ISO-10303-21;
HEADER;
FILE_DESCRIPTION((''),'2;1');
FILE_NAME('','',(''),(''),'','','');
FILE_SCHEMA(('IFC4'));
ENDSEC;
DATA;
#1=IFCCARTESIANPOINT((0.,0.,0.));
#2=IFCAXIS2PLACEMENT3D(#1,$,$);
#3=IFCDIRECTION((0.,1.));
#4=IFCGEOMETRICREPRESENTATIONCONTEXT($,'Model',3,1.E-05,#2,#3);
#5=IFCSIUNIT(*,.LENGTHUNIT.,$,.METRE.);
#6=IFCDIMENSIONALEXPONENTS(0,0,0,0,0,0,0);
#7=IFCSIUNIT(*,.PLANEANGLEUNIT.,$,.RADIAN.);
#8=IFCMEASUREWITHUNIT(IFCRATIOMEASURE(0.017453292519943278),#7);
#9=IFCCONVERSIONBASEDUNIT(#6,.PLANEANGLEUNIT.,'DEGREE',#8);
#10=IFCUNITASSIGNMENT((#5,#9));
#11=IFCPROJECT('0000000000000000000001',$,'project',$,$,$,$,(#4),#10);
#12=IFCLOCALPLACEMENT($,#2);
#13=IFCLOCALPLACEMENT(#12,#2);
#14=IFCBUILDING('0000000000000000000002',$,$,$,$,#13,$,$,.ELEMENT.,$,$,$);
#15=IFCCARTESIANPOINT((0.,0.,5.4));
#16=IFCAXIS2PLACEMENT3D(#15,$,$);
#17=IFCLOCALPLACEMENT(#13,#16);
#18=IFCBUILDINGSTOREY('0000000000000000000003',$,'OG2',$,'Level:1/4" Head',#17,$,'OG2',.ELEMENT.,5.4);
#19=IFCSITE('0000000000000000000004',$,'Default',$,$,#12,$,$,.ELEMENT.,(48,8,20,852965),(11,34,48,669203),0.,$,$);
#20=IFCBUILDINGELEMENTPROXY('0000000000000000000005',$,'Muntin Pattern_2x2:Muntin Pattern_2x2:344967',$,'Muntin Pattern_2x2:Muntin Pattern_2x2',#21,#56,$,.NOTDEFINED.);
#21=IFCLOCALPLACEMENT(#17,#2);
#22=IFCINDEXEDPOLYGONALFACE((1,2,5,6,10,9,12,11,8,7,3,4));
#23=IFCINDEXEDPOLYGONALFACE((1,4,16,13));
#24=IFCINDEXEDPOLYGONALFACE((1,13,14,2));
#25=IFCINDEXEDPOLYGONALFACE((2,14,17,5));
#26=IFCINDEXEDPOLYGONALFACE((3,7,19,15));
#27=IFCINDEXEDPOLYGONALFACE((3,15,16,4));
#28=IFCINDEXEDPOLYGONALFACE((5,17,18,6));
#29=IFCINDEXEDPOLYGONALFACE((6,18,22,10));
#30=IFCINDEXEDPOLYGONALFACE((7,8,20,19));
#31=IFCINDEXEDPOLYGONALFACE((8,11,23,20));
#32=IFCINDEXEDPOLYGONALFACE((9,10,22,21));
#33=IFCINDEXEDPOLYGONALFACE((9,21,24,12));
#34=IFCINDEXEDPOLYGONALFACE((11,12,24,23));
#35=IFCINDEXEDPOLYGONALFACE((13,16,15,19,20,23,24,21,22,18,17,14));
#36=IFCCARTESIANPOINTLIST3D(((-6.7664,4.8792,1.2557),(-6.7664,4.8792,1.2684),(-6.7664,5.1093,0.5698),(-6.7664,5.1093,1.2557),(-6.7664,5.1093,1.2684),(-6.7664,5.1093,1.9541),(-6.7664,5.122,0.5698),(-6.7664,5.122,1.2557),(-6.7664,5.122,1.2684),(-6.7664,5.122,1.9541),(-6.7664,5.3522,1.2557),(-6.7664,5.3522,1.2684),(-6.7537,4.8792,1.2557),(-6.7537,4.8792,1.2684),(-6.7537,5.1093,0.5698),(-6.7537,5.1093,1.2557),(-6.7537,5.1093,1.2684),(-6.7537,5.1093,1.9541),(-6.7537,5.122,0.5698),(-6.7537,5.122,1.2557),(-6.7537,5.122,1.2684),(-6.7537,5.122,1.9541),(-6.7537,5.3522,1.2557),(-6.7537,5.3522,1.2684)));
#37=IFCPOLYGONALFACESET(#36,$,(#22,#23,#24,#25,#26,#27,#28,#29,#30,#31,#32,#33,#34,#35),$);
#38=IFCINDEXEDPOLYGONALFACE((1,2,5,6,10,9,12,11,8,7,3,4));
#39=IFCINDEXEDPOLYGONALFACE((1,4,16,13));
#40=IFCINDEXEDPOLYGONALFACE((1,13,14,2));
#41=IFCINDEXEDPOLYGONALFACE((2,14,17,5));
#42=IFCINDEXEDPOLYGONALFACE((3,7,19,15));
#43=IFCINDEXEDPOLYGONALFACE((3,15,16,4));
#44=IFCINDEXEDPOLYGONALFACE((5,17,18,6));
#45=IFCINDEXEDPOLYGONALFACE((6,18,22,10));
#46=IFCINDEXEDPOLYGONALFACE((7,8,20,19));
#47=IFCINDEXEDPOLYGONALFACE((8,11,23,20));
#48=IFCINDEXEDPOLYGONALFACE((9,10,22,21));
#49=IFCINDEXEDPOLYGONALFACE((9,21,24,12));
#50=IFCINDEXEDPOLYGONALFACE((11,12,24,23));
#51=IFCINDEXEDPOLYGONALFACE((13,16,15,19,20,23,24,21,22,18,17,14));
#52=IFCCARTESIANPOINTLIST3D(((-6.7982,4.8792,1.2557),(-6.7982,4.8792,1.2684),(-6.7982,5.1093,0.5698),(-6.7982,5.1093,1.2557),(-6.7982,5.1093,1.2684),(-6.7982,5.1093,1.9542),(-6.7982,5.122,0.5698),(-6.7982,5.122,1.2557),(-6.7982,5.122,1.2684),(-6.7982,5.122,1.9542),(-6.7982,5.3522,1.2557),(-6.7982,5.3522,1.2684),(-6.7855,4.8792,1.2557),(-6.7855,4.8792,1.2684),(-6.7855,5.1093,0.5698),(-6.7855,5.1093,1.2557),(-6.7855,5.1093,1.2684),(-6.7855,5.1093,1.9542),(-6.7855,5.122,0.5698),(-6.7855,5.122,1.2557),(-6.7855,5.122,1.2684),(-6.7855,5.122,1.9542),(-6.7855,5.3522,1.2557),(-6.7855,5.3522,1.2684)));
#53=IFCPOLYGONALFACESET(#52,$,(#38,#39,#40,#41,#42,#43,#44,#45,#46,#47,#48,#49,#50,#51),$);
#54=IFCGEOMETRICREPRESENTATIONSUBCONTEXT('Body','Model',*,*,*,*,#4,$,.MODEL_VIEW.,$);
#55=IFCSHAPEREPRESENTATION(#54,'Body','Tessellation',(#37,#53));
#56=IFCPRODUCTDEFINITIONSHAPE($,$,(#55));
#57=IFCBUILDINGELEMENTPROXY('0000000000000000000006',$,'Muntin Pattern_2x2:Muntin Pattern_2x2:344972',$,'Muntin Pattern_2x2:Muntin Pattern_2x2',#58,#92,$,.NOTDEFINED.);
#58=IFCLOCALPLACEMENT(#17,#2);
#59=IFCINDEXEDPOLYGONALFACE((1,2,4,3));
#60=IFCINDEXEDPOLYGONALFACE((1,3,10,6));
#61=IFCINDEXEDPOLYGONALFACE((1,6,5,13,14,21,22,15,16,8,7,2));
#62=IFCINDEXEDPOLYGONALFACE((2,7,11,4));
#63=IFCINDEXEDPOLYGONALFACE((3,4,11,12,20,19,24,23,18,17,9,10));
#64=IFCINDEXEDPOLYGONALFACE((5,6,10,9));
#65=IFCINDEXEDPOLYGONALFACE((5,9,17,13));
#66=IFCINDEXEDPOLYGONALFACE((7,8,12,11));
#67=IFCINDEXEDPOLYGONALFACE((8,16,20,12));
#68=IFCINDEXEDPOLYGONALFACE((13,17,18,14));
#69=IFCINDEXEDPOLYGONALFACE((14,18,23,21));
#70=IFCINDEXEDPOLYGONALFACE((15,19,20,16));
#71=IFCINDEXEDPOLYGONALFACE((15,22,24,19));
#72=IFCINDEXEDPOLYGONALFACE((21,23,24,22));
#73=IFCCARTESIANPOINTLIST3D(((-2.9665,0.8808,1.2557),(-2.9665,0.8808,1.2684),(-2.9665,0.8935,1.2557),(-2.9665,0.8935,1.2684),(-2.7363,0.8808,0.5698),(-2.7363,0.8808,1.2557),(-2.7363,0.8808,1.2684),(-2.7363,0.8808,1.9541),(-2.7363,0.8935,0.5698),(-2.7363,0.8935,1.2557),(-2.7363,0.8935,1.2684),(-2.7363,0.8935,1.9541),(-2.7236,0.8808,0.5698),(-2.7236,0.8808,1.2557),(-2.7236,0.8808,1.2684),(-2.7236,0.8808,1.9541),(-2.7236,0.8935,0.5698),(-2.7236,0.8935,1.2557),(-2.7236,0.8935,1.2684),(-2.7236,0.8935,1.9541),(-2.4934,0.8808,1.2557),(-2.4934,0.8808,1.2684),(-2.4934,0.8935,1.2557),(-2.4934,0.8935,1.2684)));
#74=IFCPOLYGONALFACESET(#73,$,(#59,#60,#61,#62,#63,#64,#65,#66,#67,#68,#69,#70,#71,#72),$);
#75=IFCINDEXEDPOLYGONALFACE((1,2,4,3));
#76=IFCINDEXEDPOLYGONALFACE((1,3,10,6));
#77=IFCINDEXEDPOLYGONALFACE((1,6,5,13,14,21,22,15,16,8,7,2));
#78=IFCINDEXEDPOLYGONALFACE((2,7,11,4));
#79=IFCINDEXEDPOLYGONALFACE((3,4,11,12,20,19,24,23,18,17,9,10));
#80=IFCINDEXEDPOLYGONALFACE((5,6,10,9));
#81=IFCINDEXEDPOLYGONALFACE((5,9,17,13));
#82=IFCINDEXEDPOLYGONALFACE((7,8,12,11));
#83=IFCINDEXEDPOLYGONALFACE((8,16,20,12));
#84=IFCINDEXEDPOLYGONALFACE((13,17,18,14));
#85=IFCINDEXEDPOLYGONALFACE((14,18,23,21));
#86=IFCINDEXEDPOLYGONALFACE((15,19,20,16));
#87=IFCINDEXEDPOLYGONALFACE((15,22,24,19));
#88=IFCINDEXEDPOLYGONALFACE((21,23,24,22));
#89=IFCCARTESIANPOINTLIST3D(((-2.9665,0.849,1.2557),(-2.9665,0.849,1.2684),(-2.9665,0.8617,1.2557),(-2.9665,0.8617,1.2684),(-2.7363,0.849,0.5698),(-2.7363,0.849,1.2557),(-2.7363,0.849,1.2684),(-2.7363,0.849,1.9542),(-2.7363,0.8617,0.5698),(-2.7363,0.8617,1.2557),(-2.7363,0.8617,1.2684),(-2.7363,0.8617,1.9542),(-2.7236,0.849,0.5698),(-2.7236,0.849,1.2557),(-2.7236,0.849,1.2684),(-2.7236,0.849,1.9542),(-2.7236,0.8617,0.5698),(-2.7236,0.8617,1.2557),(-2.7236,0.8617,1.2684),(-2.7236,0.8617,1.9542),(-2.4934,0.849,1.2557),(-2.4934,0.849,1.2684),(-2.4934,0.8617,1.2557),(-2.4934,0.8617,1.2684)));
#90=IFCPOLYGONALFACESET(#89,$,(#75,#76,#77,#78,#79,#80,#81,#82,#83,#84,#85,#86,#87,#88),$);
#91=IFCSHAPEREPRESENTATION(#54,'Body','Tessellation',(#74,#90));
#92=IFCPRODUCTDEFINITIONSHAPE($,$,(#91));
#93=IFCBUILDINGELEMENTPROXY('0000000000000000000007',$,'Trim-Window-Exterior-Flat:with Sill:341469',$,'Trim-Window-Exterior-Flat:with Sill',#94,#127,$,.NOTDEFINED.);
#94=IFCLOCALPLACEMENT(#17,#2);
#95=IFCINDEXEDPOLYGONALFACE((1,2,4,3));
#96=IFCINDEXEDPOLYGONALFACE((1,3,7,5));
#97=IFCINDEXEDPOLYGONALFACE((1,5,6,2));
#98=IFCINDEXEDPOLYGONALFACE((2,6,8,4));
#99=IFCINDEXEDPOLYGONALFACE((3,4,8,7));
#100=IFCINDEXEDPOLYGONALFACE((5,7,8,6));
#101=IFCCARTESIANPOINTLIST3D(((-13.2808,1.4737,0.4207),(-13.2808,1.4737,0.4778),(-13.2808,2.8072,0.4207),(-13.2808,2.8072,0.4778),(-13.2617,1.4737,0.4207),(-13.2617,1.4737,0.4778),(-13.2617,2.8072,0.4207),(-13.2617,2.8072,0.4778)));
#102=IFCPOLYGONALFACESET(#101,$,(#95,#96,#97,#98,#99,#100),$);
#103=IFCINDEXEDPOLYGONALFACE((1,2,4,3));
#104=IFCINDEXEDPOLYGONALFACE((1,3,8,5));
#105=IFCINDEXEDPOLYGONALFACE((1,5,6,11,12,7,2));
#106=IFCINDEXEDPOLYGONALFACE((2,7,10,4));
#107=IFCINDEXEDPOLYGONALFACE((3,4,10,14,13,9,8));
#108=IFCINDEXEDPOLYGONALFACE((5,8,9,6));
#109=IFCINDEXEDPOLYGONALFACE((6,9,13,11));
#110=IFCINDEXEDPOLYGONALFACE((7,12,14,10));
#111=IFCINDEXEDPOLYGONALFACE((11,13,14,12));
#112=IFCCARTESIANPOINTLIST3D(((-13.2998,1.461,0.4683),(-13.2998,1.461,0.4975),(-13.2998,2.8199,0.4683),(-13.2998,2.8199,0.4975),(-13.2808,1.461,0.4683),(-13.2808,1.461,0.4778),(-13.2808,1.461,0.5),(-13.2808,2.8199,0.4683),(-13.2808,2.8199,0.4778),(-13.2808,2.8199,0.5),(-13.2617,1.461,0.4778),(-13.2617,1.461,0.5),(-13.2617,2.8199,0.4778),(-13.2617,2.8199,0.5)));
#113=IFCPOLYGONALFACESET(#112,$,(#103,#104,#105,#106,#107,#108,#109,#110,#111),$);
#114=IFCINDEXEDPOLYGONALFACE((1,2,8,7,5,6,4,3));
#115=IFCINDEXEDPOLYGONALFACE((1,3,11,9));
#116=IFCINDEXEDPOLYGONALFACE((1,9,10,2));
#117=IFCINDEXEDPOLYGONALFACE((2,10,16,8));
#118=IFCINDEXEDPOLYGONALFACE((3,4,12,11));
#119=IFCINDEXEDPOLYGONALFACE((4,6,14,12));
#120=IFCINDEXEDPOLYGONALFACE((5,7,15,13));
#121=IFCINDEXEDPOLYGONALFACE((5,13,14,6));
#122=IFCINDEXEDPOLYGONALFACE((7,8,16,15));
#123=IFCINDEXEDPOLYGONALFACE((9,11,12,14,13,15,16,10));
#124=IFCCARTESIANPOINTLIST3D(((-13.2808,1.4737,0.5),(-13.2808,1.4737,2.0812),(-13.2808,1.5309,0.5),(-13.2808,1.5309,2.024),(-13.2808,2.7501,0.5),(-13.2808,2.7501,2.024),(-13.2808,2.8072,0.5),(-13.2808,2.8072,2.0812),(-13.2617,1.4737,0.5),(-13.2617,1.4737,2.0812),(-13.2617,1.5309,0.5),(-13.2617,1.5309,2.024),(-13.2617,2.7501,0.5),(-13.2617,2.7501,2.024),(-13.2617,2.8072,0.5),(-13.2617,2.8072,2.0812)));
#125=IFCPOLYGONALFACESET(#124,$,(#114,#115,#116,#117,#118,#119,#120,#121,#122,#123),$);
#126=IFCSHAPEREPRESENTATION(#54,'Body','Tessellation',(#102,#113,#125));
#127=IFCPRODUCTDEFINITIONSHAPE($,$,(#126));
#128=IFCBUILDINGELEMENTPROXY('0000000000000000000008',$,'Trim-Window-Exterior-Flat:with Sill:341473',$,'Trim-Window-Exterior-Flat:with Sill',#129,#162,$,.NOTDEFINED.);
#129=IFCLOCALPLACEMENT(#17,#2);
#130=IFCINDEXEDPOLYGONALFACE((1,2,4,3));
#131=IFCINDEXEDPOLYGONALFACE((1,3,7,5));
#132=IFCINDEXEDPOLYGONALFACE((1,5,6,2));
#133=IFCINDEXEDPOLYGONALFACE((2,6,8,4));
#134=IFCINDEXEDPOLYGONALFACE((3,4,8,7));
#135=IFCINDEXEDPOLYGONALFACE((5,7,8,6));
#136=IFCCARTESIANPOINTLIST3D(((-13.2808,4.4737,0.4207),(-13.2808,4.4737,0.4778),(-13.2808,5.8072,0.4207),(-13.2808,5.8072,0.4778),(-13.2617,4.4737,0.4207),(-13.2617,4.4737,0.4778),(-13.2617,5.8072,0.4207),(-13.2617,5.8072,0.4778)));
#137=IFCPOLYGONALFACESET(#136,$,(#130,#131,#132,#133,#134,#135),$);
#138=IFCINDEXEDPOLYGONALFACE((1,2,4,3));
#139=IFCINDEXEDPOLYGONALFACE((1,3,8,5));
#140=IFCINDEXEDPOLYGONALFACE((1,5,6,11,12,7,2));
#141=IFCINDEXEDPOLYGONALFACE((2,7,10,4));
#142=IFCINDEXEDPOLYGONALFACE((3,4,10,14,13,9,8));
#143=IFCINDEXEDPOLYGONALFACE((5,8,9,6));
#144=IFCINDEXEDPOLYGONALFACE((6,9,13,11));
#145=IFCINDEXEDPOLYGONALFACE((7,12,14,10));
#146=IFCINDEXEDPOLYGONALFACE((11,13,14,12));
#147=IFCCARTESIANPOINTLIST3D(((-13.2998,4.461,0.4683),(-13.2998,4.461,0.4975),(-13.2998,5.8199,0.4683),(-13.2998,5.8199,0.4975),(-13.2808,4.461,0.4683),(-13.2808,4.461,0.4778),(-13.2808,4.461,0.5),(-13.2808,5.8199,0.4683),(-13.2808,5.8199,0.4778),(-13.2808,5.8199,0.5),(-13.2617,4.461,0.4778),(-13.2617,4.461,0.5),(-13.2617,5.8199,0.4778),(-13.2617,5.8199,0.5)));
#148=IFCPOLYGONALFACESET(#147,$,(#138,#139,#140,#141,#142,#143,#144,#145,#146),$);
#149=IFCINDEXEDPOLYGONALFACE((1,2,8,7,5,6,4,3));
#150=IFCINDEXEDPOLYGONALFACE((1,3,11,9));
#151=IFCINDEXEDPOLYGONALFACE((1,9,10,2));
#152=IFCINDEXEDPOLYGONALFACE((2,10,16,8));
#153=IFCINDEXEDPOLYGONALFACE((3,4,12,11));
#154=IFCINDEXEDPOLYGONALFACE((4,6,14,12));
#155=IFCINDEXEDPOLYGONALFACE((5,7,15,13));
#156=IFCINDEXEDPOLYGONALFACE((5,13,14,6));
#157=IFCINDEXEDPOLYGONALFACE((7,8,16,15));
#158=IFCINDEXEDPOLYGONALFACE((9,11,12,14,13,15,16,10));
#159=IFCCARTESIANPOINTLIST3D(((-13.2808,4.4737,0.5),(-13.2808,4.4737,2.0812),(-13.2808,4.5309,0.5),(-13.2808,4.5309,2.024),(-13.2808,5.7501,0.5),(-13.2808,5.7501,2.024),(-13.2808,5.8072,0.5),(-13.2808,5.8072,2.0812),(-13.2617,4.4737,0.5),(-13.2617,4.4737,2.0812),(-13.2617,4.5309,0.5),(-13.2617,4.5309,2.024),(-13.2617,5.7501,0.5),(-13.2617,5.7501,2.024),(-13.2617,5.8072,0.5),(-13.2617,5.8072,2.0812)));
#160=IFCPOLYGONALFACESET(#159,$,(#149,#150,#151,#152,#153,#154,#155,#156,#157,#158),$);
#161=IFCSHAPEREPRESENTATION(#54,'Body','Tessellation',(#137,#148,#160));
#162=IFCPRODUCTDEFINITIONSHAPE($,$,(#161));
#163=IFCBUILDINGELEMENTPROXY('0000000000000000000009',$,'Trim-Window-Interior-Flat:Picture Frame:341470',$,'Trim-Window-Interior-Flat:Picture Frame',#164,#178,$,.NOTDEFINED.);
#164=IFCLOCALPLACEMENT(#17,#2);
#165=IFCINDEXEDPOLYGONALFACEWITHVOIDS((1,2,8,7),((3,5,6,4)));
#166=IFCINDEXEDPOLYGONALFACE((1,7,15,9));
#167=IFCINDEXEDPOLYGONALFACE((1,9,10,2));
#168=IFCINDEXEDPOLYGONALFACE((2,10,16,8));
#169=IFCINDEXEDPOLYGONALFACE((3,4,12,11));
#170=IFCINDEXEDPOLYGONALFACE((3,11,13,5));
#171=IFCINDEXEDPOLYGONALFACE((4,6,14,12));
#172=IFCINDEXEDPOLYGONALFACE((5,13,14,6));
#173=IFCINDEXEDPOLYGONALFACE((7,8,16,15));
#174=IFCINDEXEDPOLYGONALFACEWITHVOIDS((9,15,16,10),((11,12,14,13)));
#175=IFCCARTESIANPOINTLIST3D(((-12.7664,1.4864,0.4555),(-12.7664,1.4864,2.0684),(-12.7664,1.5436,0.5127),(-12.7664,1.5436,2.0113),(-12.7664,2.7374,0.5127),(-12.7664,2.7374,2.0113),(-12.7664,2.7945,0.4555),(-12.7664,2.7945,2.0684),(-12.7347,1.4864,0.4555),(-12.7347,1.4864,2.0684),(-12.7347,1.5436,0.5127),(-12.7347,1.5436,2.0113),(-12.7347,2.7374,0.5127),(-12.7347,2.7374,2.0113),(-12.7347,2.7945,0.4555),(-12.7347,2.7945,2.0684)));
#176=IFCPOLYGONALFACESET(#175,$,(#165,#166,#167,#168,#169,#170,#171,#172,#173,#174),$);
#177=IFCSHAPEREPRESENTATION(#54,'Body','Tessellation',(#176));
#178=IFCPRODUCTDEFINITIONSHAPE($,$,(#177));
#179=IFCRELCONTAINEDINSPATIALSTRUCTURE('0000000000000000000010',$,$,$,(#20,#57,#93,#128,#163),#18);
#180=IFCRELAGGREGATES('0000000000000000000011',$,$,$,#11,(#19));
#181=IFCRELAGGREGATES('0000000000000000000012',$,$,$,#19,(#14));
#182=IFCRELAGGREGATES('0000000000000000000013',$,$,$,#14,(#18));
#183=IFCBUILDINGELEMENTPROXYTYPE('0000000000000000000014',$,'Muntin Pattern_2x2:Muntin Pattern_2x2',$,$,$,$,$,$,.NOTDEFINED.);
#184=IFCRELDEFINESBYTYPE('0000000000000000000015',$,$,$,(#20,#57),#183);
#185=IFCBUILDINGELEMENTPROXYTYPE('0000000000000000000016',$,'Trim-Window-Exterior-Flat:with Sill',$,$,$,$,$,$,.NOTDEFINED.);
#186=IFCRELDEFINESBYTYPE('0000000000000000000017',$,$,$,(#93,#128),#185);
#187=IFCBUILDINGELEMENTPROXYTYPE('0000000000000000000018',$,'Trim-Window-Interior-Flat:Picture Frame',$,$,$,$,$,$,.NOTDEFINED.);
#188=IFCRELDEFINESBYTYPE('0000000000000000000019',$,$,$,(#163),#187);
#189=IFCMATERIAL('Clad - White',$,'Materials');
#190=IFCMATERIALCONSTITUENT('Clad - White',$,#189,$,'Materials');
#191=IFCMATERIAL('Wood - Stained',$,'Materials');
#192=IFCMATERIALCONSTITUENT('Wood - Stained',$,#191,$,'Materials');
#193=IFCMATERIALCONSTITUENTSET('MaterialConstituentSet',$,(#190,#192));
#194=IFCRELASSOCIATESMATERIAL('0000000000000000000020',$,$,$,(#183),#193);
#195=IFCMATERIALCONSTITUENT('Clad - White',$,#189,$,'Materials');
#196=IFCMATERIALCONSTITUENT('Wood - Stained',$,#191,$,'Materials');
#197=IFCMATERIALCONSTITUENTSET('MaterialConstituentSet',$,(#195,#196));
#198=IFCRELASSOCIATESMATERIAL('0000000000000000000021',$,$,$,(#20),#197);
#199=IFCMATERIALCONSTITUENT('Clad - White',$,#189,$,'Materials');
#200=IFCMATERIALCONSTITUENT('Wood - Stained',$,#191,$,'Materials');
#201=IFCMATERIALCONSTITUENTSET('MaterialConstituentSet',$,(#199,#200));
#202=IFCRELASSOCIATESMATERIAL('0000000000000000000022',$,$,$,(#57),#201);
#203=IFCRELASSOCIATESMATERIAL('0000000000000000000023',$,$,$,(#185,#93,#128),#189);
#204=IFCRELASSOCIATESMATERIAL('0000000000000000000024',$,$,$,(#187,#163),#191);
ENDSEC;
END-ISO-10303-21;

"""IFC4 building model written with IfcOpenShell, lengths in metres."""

from ifc_helpers import new_model, entity, si_unit, converted_unit, direction, frame, origin, place, context, subcontext, project, spatial, indexed_curve, outline, extrude, source, transform, mapped, material, constituent, constituent_set, type_object, type_shapes, element, save


model = new_model("IFC4")

# Units and contexts
model_context = context("Model", 3, precision=1e-05, world=origin(), true_north=direction((0.0, 1.0)))
body_context = subcontext(model_context, "Body", "Model", "MODEL_VIEW")
ifc_project = project(units=[si_unit("LENGTHUNIT", "METRE"), converted_unit("PLANEANGLEUNIT", "DEGREE", entity("IfcRatioMeasure", 0.017453292519943278), si_unit("PLANEANGLEUNIT", "RADIAN"), dimensions=[0, 0, 0, 0, 0, 0, 0])], contexts=[model_context])

# Site, building, storey
site_placement = place(None, origin())
site = spatial("IfcSite", under=ifc_project, at=site_placement, Name="Default", CompositionType="ELEMENT", RefLatitude=(48, 8, 20, 852965), RefLongitude=(11, 34, 48, 669203), RefElevation=0.0)
building_placement = place(site_placement, origin())
building = spatial("IfcBuilding", under=site, at=building_placement, CompositionType="ELEMENT")
storey_placement = place(building_placement, frame((0.0, 0.0, 5.4)))
storey = spatial("IfcBuildingStorey", under=building, at=storey_placement, Name="OG2", ObjectType="Level:1/4\" Head", LongName="OG2", CompositionType="ELEMENT", Elevation=5.4)

# Building element proxies
ifc_material_1 = material(Name="Clad - White", Category="Materials")
ifc_material_2 = material(Name="Wood - Stained", Category="Materials")
ifc_constituent_1 = constituent(ifc_material_1, Name="Clad - White", Category="Materials")
ifc_constituent_2 = constituent(ifc_material_2, Name="Wood - Stained", Category="Materials")
ifc_constituent_set_1 = constituent_set(constituents=[ifc_constituent_1, ifc_constituent_2], Name="MaterialConstituentSet")
building_element_proxy_type_1 = type_object("IfcBuildingElementProxyType", Name="Muntin Pattern_2x2:Muntin Pattern_2x2", PredefinedType="NOTDEFINED", material=ifc_constituent_set_1)
shared_shape_1 = source(origin(), body_context, "Body", "SweptSolid", [
    extrude(outline(indexed_curve([(0.0064, -0.0064), (0.6921, -0.0064), (0.6921, 0.0063), (0.0064, 0.0063), (0.0064, 0.2365), (-0.0063, 0.2365), (-0.0063, 0.0063), (-0.6922, 0.0063), (-0.6922, -0.0064), (-0.0063, -0.0064), (-0.0063, -0.2365), (0.0064, -0.2365), (0.0064, -0.0064)], self_intersect=False)), frame((0.0, 0.0095, 0.6921), z_axis=(0.0, 1.0, 0.0), x_axis=(0.0, 0.0, 1.0)), (0.0, 0.0, 1.0), 0.0127),
    extrude(outline(indexed_curve([(0.0064, -0.0064), (0.6922, -0.0064), (0.6922, 0.0063), (0.0064, 0.0063), (0.0064, 0.2365), (-0.0063, 0.2365), (-0.0063, 0.0063), (-0.6922, 0.0063), (-0.6922, -0.0064), (-0.0063, -0.0064), (-0.0063, -0.2365), (0.0064, -0.2365), (0.0064, -0.0064)], self_intersect=False)), frame((0.0, -0.0222, 0.6922), z_axis=(0.0, 1.0, 0.0), x_axis=(0.0, 0.0, 1.0)), (0.0, 0.0, 1.0), 0.0127),
])
type_shapes(building_element_proxy_type_1, [shared_shape_1])
ifc_constituent_3 = constituent(ifc_material_1, Name="Clad - White", Category="Materials")
ifc_constituent_4 = constituent(ifc_material_2, Name="Wood - Stained", Category="Materials")
ifc_constituent_set_2 = constituent_set(constituents=[ifc_constituent_3, ifc_constituent_4], Name="MaterialConstituentSet")
proxy_1_placement = place(storey_placement, frame((-6.7759, 5.1157, 0.5699), z_axis=(0.0, 0.0, 1.0), x_axis=(0.0, -1.0, 0.0)))
element("IfcBuildingElementProxy", 1, at=proxy_1_placement, inside=storey, type_object=building_element_proxy_type_1, material=ifc_constituent_set_2, Name="Muntin Pattern_2x2:Muntin Pattern_2x2:344967", ObjectType="Muntin Pattern_2x2:Muntin Pattern_2x2", PredefinedType="NOTDEFINED", context=body_context, shape_type="MappedRepresentation", body=[
    mapped(shared_shape_1, transform((0.0, 0.0, 0.0), scale=1.0)),
])
ifc_constituent_5 = constituent(ifc_material_1, Name="Clad - White", Category="Materials")
ifc_constituent_6 = constituent(ifc_material_2, Name="Wood - Stained", Category="Materials")
ifc_constituent_set_3 = constituent_set(constituents=[ifc_constituent_5, ifc_constituent_6], Name="MaterialConstituentSet")
proxy_2_placement = place(storey_placement, frame((-2.73, 0.8713, 0.5699)))
element("IfcBuildingElementProxy", 2, at=proxy_2_placement, inside=storey, type_object=building_element_proxy_type_1, material=ifc_constituent_set_3, Name="Muntin Pattern_2x2:Muntin Pattern_2x2:344972", ObjectType="Muntin Pattern_2x2:Muntin Pattern_2x2", PredefinedType="NOTDEFINED", context=body_context, shape_type="MappedRepresentation", body=[
    mapped(shared_shape_1, transform((0.0, 0.0, 0.0), scale=1.0)),
])
building_element_proxy_type_2 = type_object("IfcBuildingElementProxyType", Name="Trim-Window-Exterior-Flat:with Sill", PredefinedType="NOTDEFINED", material=ifc_material_1)
shared_shape_2 = source(origin(), body_context, "Body", "SweptSolid", [
    extrude(outline(indexed_curve([(-0.0286, -0.6667), (0.0286, -0.6667), (0.0286, 0.6667), (-0.0286, 0.6667), (-0.0286, -0.6667)], self_intersect=False)), frame((0.0, 1.5748, 0.0), z_axis=(0.0, 0.0, 1.0), x_axis=(0.0, 1.0, 0.0)), (0.0, 0.0, 1.0), 0.019),
    extrude(outline(indexed_curve([(-0.016, -0.019), (0.0133, -0.019), (0.0158, 0.0), (0.0158, 0.019), (-0.0064, 0.019), (-0.0064, 0.0), (-0.016, 0.0), (-0.016, -0.019)], self_intersect=False)), frame((-0.6794, 1.5398, 0.019), z_axis=(1.0, 0.0, 0.0), x_axis=(0.0, -1.0, 0.0)), (0.0, 0.0, 1.0), 1.3589),
    extrude(outline(indexed_curve([(-0.6667, -0.8049), (0.6667, -0.8049), (0.6667, 0.7763), (0.6096, 0.7763), (0.6096, -0.7477), (-0.6096, -0.7477), (-0.6096, 0.7763), (-0.6667, 0.7763), (-0.6667, -0.8049)], self_intersect=False)), frame((0.0, 0.7477, 0.0)), (0.0, 0.0, 1.0), 0.019),
])
type_shapes(building_element_proxy_type_2, [shared_shape_2])
for number, where, z_axis, x_axis, name in (
    (3, (-13.2617, 2.1405, 2.024), (-1.0, 0.0, 0.0), (0.0, 1.0, 0.0), "Trim-Window-Exterior-Flat:with Sill:341469"),
    (4, (-13.2617, 5.1405, 2.024), (-1.0, 0.0, 0.0), (0.0, 1.0, 0.0), "Trim-Window-Exterior-Flat:with Sill:341473"),
):
    element("IfcBuildingElementProxy", number, at=place(storey_placement, frame(where, z_axis=z_axis, x_axis=x_axis)), inside=storey, type_object=building_element_proxy_type_2, material=ifc_material_1, Name=name, ObjectType="Trim-Window-Exterior-Flat:with Sill", PredefinedType="NOTDEFINED", context=body_context, shape_type="MappedRepresentation", body=[
        mapped(shared_shape_2, transform((0.0, 0.0, 0.0), scale=1.0)),
    ])
building_element_proxy_type_3 = type_object("IfcBuildingElementProxyType", Name="Trim-Window-Interior-Flat:Picture Frame", PredefinedType="NOTDEFINED", material=ifc_material_2)
shared_shape_3 = source(origin(), body_context, "Body", "SweptSolid", [
    extrude(outline(indexed_curve([(-0.8064, -0.654), (0.8064, -0.654), (0.8064, 0.654), (-0.8064, 0.654), (-0.8064, -0.654)], self_intersect=False), holes=[indexed_curve([(-0.7493, -0.5969), (-0.7493, 0.5969), (0.7493, 0.5969), (0.7493, -0.5969), (-0.7493, -0.5969)], self_intersect=False)]), frame((0.0, 0.762, 0.0), z_axis=(0.0, 0.0, 1.0), x_axis=(0.0, 1.0, 0.0)), (0.0, 0.0, 1.0), 0.0317),
])
type_shapes(building_element_proxy_type_3, [shared_shape_3])
for number, where, z_axis, x_axis, name in (
    (5, (-12.7664, 2.1405, 2.024), (1.0, 0.0, 0.0), (0.0, -1.0, 0.0), "Trim-Window-Interior-Flat:Picture Frame:341470"),
):
    element("IfcBuildingElementProxy", number, at=place(storey_placement, frame(where, z_axis=z_axis, x_axis=x_axis)), inside=storey, type_object=building_element_proxy_type_3, material=ifc_material_2, Name=name, ObjectType="Trim-Window-Interior-Flat:Picture Frame", PredefinedType="NOTDEFINED", context=body_context, shape_type="MappedRepresentation", body=[
        mapped(shared_shape_3, transform((0.0, 0.0, 0.0), scale=1.0)),
    ])

save(model, "model.ifc")
